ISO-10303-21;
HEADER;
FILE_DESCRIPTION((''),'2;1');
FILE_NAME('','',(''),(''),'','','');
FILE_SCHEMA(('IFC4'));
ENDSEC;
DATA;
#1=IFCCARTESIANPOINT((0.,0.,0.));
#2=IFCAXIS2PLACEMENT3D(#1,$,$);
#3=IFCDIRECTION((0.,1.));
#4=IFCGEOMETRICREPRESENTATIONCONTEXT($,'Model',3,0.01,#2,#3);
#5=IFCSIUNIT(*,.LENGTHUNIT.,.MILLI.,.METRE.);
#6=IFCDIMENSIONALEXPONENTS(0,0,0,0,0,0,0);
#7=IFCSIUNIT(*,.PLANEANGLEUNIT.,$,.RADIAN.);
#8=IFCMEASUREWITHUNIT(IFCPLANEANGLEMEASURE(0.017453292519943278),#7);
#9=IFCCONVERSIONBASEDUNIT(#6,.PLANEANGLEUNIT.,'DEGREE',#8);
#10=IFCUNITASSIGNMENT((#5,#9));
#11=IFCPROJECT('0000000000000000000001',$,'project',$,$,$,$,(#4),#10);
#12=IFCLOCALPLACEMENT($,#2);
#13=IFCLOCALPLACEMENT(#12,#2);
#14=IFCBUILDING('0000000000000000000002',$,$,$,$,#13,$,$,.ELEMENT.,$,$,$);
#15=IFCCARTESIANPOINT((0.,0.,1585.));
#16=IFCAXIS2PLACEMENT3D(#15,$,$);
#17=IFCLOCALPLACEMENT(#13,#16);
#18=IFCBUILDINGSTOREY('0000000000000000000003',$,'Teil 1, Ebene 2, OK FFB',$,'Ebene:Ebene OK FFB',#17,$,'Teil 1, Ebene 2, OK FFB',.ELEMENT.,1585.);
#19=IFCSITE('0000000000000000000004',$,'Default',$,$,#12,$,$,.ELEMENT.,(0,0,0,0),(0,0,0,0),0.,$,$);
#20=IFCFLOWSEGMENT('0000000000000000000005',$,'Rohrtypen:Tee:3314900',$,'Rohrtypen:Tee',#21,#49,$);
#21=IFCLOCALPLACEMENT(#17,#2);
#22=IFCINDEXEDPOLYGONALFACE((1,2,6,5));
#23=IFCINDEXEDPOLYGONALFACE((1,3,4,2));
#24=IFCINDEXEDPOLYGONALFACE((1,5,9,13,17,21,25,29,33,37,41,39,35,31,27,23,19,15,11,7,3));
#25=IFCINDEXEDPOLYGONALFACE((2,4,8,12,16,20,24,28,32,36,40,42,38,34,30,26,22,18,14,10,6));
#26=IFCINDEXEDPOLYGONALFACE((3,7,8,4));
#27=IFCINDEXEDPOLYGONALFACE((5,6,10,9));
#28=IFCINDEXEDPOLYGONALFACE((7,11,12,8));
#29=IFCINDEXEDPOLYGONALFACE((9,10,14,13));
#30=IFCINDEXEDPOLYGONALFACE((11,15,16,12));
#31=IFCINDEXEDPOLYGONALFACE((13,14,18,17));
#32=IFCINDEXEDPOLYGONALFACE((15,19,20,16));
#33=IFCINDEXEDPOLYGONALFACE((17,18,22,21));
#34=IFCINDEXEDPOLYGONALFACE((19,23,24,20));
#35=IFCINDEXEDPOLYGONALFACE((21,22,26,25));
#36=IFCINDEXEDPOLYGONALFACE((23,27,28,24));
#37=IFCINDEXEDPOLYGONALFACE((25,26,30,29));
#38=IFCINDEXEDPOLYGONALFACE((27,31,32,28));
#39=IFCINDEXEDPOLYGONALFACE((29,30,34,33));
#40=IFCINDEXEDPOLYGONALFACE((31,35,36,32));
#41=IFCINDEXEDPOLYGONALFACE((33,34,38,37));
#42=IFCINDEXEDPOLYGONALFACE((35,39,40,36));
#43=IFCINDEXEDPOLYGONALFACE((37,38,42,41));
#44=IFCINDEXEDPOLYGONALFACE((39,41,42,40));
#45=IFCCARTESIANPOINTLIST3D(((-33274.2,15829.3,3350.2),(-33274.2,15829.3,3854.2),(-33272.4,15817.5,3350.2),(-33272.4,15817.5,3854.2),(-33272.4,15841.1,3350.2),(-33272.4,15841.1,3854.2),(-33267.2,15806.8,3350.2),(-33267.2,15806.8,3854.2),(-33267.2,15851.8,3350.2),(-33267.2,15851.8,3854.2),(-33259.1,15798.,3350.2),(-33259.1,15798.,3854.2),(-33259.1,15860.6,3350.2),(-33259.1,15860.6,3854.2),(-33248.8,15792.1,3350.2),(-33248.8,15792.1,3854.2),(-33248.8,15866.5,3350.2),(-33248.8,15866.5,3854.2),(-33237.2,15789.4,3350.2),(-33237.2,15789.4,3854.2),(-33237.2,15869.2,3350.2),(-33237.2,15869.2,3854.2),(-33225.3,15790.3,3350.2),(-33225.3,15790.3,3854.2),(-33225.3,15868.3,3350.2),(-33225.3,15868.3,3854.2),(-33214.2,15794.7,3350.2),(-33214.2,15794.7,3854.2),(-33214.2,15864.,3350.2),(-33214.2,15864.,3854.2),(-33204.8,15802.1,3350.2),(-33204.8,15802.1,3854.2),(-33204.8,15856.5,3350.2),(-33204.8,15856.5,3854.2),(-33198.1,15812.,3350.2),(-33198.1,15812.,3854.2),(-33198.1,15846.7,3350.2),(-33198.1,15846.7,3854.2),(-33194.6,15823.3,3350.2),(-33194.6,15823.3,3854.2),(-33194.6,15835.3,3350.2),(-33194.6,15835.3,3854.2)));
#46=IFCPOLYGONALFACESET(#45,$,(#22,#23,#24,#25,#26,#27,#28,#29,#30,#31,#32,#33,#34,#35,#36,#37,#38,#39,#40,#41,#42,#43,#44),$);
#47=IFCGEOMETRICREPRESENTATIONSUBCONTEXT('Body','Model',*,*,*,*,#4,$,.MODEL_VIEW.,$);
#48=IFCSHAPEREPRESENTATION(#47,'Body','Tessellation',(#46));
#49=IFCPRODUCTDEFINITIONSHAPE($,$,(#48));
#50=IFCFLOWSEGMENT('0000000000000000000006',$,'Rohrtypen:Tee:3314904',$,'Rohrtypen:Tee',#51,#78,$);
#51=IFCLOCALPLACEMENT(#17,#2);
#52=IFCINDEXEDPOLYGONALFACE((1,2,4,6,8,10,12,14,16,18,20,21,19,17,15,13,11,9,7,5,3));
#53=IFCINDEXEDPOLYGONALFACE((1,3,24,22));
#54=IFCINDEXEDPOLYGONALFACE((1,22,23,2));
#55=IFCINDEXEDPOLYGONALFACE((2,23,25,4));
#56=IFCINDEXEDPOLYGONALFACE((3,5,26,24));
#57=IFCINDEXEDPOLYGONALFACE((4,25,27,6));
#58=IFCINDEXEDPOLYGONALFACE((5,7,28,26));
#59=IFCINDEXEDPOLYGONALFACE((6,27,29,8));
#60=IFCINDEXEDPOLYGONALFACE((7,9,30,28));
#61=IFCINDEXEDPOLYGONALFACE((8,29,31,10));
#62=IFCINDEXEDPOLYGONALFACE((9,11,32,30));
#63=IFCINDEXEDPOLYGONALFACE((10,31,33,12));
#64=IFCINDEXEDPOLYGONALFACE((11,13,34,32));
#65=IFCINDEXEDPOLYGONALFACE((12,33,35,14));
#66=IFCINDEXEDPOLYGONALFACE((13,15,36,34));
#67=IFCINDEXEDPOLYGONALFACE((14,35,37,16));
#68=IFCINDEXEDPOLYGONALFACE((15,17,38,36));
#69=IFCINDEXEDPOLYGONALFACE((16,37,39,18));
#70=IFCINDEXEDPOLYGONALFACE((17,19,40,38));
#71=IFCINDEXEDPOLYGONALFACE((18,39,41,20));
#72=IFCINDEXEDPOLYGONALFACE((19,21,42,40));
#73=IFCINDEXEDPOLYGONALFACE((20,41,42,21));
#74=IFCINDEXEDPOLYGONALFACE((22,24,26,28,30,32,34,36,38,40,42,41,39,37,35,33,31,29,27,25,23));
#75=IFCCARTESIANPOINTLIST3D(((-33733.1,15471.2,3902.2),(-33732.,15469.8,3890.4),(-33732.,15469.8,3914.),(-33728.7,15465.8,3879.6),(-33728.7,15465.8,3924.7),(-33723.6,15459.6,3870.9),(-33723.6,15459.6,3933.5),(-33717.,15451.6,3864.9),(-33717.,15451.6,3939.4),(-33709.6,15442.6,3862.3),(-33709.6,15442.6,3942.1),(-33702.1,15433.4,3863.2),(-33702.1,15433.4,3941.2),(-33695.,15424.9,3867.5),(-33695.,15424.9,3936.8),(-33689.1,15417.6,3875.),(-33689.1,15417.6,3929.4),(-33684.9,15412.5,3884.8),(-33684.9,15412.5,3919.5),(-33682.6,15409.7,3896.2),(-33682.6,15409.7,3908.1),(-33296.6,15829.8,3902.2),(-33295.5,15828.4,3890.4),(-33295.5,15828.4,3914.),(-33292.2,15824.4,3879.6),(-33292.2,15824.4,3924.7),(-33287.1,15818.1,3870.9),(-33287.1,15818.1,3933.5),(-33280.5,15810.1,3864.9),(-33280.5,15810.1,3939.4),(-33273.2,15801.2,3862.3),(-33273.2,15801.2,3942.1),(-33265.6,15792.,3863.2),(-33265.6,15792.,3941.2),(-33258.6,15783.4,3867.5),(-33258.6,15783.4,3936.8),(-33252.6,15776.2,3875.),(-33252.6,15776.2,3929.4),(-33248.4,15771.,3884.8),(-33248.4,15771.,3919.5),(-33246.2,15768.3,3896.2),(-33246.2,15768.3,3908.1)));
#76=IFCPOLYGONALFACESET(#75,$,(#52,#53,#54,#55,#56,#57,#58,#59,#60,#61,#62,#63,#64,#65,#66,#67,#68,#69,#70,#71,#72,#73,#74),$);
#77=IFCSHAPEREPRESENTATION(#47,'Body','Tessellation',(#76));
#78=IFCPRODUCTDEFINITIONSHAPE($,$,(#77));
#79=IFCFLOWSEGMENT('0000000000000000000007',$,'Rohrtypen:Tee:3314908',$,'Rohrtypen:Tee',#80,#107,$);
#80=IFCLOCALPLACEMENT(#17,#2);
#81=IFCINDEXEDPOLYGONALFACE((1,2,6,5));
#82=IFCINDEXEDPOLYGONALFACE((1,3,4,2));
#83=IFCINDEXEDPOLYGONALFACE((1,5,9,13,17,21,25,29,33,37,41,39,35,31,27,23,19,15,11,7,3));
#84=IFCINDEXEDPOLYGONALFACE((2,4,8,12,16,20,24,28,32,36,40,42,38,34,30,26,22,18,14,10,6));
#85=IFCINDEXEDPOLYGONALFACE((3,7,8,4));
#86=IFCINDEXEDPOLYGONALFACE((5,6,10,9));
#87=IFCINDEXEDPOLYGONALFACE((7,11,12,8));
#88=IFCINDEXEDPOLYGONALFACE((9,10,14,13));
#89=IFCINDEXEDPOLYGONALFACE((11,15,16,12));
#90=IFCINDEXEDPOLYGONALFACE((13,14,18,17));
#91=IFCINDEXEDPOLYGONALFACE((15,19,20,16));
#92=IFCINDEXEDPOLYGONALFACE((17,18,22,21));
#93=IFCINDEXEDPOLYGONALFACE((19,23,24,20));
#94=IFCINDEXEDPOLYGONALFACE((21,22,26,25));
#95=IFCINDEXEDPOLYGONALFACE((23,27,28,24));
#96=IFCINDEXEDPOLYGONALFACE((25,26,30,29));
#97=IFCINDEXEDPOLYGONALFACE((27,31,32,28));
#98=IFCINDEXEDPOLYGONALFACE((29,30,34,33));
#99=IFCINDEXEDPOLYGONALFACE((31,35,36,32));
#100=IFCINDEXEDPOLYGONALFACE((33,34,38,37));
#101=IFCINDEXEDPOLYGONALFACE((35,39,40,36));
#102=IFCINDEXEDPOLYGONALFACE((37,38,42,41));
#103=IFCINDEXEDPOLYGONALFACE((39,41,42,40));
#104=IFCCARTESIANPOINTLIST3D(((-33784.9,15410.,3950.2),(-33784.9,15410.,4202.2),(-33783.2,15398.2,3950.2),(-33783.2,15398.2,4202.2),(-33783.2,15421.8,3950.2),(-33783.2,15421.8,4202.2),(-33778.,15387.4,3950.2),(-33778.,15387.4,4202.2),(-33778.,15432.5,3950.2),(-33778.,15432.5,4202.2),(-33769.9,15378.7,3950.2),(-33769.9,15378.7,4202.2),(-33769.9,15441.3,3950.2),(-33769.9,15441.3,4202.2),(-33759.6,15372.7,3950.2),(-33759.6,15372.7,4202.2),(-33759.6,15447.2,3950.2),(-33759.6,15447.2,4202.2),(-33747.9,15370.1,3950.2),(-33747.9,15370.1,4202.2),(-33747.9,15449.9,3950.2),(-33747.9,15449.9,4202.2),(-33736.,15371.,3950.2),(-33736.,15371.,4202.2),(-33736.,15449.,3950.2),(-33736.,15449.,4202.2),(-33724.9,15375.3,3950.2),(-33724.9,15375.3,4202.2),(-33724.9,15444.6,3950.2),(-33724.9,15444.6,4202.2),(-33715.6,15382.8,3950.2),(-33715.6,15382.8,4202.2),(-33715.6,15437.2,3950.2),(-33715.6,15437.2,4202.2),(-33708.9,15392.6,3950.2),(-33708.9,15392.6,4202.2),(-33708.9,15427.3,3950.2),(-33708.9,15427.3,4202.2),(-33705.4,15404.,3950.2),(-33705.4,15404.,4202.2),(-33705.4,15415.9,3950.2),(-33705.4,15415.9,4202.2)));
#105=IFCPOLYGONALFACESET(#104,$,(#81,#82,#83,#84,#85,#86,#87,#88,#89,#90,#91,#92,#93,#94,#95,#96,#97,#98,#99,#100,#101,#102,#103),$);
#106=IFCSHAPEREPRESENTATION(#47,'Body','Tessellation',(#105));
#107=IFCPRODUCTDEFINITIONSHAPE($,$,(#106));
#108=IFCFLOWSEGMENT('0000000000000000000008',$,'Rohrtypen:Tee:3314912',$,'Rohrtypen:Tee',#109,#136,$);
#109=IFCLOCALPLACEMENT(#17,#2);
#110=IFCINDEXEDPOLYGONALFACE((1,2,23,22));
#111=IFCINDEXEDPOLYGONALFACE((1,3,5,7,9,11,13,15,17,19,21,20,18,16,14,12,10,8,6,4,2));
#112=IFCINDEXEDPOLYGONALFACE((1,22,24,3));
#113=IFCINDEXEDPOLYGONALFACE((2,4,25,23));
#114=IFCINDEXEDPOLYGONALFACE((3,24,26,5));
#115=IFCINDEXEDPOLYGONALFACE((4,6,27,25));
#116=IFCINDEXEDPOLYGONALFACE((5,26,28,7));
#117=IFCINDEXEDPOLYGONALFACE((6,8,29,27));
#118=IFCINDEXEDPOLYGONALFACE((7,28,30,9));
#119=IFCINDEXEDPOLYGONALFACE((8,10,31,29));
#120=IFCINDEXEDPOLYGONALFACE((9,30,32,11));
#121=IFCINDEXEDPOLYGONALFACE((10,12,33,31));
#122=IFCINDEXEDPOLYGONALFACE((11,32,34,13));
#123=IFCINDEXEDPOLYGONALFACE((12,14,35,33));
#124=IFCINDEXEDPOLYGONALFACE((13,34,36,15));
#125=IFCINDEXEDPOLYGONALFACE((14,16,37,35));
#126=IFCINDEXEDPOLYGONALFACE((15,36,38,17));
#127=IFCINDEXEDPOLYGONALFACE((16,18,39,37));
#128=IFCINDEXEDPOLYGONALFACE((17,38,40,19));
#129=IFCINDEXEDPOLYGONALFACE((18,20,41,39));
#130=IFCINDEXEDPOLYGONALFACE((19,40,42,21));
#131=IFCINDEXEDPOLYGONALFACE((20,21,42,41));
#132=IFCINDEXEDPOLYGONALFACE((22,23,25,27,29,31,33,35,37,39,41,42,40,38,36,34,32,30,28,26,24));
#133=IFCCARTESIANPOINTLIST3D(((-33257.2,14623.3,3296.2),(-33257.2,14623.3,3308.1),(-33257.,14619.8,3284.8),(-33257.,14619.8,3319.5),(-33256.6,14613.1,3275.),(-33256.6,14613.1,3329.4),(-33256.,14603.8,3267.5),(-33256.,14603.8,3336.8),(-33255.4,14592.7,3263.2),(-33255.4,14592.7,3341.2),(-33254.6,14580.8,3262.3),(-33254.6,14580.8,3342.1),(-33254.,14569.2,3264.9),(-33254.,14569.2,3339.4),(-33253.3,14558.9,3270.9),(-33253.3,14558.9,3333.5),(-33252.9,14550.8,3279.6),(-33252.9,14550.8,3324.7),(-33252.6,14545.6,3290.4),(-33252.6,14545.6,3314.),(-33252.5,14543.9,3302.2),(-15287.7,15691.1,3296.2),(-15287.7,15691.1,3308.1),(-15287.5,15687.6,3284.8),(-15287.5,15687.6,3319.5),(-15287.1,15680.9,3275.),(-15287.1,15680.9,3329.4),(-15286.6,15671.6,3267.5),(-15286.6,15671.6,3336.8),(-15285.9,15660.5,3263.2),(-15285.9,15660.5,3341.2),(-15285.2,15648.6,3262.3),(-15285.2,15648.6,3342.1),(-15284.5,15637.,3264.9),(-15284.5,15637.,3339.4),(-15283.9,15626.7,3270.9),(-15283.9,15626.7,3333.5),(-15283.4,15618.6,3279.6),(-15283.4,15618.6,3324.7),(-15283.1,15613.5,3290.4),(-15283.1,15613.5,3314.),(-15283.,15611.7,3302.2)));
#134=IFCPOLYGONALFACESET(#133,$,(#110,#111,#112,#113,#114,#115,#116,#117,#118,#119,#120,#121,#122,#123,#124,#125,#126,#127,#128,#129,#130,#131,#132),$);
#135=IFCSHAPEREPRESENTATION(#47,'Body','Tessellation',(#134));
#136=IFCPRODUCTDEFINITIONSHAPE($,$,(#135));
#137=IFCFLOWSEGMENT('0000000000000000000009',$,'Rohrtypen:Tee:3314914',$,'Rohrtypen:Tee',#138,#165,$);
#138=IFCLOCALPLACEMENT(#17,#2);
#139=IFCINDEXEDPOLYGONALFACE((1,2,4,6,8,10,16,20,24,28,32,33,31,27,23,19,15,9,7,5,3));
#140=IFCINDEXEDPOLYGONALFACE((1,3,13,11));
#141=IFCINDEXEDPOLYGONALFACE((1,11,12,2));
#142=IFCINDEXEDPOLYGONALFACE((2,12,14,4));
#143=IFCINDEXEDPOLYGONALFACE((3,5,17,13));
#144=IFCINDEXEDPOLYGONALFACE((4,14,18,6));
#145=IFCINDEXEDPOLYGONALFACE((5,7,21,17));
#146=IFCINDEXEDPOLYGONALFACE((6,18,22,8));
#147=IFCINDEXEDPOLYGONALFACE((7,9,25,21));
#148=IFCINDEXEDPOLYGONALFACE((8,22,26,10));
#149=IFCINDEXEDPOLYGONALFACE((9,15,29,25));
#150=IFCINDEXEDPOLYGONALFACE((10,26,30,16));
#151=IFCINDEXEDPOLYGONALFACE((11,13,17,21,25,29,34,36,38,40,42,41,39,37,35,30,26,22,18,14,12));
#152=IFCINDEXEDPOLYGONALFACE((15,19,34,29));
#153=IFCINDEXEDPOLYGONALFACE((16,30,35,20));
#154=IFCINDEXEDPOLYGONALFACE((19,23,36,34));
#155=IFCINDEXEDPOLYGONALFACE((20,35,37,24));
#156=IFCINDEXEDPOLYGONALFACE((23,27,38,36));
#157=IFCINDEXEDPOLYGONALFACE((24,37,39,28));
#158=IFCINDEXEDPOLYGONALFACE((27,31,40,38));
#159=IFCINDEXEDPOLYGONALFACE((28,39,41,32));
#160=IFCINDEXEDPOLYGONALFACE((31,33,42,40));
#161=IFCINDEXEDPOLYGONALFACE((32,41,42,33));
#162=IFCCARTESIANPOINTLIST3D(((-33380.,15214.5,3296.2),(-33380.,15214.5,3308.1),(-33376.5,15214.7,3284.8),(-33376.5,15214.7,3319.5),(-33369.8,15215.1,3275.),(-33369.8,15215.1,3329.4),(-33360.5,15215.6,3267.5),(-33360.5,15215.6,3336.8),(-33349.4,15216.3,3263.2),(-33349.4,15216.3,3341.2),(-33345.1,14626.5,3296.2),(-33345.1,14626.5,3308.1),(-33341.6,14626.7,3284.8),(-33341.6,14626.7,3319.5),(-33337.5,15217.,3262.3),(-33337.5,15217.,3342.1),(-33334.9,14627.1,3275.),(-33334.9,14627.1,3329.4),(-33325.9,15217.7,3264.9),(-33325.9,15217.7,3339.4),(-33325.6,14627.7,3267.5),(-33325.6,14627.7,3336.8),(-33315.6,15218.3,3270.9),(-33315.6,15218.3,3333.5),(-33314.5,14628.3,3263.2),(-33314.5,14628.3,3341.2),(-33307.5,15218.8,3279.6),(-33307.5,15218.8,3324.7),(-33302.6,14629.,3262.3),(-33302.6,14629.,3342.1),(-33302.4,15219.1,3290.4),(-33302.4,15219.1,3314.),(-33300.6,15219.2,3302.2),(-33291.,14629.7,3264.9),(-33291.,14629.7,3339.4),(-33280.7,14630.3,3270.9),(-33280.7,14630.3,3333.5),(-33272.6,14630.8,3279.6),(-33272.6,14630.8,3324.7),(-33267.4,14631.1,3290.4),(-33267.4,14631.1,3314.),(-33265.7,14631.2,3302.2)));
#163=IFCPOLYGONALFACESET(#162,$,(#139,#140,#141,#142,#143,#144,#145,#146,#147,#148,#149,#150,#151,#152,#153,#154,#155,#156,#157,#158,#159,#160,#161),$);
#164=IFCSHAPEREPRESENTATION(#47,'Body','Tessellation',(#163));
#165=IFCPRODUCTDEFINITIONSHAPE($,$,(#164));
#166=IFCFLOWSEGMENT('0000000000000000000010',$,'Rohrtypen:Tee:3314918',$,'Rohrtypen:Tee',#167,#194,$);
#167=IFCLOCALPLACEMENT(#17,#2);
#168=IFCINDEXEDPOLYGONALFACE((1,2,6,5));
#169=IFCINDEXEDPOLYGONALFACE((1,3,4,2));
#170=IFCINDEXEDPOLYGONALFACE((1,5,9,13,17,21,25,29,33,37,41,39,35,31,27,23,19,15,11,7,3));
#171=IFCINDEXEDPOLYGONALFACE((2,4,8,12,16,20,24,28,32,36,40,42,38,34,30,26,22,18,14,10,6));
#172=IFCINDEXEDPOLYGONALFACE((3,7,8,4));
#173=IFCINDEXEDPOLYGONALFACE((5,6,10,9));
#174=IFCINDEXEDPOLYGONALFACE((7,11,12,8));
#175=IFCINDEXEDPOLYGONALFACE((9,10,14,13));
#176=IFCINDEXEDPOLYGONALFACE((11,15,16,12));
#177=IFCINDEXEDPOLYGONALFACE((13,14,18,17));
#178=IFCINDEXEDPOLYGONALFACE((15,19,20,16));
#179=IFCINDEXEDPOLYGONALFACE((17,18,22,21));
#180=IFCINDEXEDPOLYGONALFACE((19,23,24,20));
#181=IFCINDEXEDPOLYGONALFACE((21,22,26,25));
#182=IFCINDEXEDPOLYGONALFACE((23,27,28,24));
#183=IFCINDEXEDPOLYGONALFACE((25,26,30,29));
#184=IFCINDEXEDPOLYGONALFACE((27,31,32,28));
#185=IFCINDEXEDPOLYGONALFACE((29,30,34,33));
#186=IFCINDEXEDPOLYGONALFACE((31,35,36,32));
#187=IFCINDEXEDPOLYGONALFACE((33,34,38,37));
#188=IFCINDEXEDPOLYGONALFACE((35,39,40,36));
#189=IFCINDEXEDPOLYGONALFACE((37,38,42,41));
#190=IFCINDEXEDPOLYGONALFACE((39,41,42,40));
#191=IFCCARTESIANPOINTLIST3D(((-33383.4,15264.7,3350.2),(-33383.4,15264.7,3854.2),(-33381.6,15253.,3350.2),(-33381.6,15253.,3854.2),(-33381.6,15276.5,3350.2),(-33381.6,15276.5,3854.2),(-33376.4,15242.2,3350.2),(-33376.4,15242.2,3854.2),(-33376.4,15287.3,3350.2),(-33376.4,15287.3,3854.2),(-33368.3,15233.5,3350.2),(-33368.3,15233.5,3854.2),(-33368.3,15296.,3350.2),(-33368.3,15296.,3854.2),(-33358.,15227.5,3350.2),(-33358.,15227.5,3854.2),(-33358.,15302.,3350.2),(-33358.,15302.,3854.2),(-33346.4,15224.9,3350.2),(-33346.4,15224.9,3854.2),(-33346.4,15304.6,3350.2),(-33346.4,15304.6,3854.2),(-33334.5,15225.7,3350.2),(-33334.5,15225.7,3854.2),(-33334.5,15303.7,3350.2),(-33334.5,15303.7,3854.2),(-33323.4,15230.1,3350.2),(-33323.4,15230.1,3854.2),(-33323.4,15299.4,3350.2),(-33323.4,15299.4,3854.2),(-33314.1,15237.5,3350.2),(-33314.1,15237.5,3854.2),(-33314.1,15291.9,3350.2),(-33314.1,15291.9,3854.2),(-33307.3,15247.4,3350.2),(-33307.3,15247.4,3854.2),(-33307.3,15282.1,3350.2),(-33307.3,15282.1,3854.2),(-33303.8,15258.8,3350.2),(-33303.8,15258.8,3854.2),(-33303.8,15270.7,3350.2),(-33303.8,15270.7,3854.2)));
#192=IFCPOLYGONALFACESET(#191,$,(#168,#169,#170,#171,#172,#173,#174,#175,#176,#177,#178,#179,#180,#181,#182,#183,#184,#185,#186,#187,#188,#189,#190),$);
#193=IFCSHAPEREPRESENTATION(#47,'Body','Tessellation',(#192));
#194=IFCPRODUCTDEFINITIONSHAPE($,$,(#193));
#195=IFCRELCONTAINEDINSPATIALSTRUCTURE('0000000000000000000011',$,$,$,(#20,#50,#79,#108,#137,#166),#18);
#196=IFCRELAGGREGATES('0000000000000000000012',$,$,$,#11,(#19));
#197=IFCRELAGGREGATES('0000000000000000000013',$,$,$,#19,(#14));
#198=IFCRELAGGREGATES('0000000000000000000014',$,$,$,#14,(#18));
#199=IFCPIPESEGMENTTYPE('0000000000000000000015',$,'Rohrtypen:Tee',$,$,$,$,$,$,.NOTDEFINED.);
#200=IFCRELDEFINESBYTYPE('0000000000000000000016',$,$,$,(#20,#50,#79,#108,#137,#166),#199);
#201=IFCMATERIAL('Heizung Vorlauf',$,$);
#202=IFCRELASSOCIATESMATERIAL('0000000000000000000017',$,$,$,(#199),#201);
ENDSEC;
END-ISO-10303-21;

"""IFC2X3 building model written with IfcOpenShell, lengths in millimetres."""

from ifc_helpers import new_model, entity, si_unit, converted_unit, direction, frame, frame_2d, origin, origin_2d_with_axis, place, context, subcontext, project, spatial, circle, extrude, material, type_object, element, save


model = new_model("IFC2X3")

# Units and contexts
model_context = context("Model", 3, precision=0.01, world=origin(), true_north=direction((0.0, 1.0)))
body_context = subcontext(model_context, "Body", "Model", "MODEL_VIEW")
ifc_project = project(units=[si_unit("LENGTHUNIT", "METRE", prefix="MILLI"), converted_unit("PLANEANGLEUNIT", "DEGREE", entity("IfcPlaneAngleMeasure", 0.017453292519943278), si_unit("PLANEANGLEUNIT", "RADIAN"), dimensions=[0, 0, 0, 0, 0, 0, 0])], contexts=[model_context])

# Site, building, storey
site_placement = place(None, origin())
site = spatial("IfcSite", under=ifc_project, at=site_placement, Name="Default", CompositionType="ELEMENT", RefLatitude=(0, 0, 0, 0), RefLongitude=(0, 0, 0, 0), RefElevation=0.0)
building_placement = place(site_placement, origin())
building = spatial("IfcBuilding", under=site, at=building_placement, CompositionType="ELEMENT")
storey_placement = place(building_placement, frame((0.0, 0.0, 1585.0)))
storey = spatial("IfcBuildingStorey", under=building, at=storey_placement, Name="Teil 1, Ebene 2, OK FFB", ObjectType="Ebene:Ebene OK FFB", LongName="Teil 1, Ebene 2, OK FFB", CompositionType="ELEMENT", Elevation=1585.0)

# Flow segments
ifc_material = material(Name="Heizung Vorlauf")
pipe_segment_type = type_object("IfcPipeSegmentType", Name="Rohrtypen:Tee", PredefinedType="NOTDEFINED", material=ifc_material)
flow_segment_1_placement = place(storey_placement, origin())
element("IfcFlowSegment", 1, at=flow_segment_1_placement, inside=storey, type_object=pipe_segment_type, Name="Rohrtypen:Tee:3314900", ObjectType="Rohrtypen:Tee", context=body_context, shape_type="SweptSolid", body=[
    extrude(circle(Radius=40.0, at=origin_2d_with_axis()), frame((-33234.2, 15829.3, 3350.2), z_axis=(0.0, 0.0, 1.0), x_axis=(-1.0, 0.0, 0.0)), (0.0, 0.0, 1.0), 504.0),
])
flow_segment_2_placement = place(storey_placement, origin())
element("IfcFlowSegment", 2, at=flow_segment_2_placement, inside=storey, type_object=pipe_segment_type, Name="Rohrtypen:Tee:3314904", ObjectType="Rohrtypen:Tee", context=body_context, shape_type="SweptSolid", body=[
    extrude(circle(Radius=40.0, at=frame_2d((0.0, 0.0), x_axis=(1.0, 0.0))), frame((-33707.7, 15440.3, 3902.2), z_axis=(0.772725, 0.634741, 0.0), x_axis=(-0.634741, 0.772725, 0.0)), (0.0, 0.0, 1.0), 564.9),
])
flow_segment_3_placement = place(storey_placement, origin())
element("IfcFlowSegment", 3, at=flow_segment_3_placement, inside=storey, type_object=pipe_segment_type, Name="Rohrtypen:Tee:3314908", ObjectType="Rohrtypen:Tee", context=body_context, shape_type="SweptSolid", body=[
    extrude(circle(Radius=40.0, at=origin_2d_with_axis()), frame((-33744.9, 15410.0, 3950.2), z_axis=(0.0, 0.0, 1.0), x_axis=(-1.0, 0.0, 0.0)), (0.0, 0.0, 1.0), 252.0),
])
flow_segment_4_placement = place(storey_placement, origin())
element("IfcFlowSegment", 4, at=flow_segment_4_placement, inside=storey, type_object=pipe_segment_type, Name="Rohrtypen:Tee:3314912", ObjectType="Rohrtypen:Tee", context=body_context, shape_type="SweptSolid", body=[
    extrude(circle(Radius=40.0, at=frame_2d((0.0, 0.0), x_axis=(1.0, 0.0))), frame((-33254.8, 14583.8, 3302.2), z_axis=(0.998239, 0.059319, 0.0), x_axis=(0.059319, -0.998239, 0.0)), (0.0, 0.0, 1.0), 18001.1),
])
flow_segment_5_placement = place(storey_placement, origin())
element("IfcFlowSegment", 5, at=flow_segment_5_placement, inside=storey, type_object=pipe_segment_type, Name="Rohrtypen:Tee:3314914", ObjectType="Rohrtypen:Tee", context=body_context, shape_type="SweptSolid", body=[
    extrude(circle(Radius=40.0, at=frame_2d((0.0, 0.0), x_axis=(1.0, 0.0))), frame((-33305.6, 14628.9, 3302.2), z_axis=(-0.059319, 0.998239, 0.0), x_axis=(0.998239, 0.059319, 0.0)), (0.0, 0.0, 1.0), 589.0),
])
flow_segment_6_placement = place(storey_placement, origin())
element("IfcFlowSegment", 6, at=flow_segment_6_placement, inside=storey, type_object=pipe_segment_type, Name="Rohrtypen:Tee:3314918", ObjectType="Rohrtypen:Tee", context=body_context, shape_type="SweptSolid", body=[
    extrude(circle(Radius=40.0, at=origin_2d_with_axis()), frame((-33343.4, 15264.7, 3350.2), z_axis=(0.0, 0.0, 1.0), x_axis=(-1.0, 0.0, 0.0)), (0.0, 0.0, 1.0), 504.0),
])

save(model, "model.ifc")
